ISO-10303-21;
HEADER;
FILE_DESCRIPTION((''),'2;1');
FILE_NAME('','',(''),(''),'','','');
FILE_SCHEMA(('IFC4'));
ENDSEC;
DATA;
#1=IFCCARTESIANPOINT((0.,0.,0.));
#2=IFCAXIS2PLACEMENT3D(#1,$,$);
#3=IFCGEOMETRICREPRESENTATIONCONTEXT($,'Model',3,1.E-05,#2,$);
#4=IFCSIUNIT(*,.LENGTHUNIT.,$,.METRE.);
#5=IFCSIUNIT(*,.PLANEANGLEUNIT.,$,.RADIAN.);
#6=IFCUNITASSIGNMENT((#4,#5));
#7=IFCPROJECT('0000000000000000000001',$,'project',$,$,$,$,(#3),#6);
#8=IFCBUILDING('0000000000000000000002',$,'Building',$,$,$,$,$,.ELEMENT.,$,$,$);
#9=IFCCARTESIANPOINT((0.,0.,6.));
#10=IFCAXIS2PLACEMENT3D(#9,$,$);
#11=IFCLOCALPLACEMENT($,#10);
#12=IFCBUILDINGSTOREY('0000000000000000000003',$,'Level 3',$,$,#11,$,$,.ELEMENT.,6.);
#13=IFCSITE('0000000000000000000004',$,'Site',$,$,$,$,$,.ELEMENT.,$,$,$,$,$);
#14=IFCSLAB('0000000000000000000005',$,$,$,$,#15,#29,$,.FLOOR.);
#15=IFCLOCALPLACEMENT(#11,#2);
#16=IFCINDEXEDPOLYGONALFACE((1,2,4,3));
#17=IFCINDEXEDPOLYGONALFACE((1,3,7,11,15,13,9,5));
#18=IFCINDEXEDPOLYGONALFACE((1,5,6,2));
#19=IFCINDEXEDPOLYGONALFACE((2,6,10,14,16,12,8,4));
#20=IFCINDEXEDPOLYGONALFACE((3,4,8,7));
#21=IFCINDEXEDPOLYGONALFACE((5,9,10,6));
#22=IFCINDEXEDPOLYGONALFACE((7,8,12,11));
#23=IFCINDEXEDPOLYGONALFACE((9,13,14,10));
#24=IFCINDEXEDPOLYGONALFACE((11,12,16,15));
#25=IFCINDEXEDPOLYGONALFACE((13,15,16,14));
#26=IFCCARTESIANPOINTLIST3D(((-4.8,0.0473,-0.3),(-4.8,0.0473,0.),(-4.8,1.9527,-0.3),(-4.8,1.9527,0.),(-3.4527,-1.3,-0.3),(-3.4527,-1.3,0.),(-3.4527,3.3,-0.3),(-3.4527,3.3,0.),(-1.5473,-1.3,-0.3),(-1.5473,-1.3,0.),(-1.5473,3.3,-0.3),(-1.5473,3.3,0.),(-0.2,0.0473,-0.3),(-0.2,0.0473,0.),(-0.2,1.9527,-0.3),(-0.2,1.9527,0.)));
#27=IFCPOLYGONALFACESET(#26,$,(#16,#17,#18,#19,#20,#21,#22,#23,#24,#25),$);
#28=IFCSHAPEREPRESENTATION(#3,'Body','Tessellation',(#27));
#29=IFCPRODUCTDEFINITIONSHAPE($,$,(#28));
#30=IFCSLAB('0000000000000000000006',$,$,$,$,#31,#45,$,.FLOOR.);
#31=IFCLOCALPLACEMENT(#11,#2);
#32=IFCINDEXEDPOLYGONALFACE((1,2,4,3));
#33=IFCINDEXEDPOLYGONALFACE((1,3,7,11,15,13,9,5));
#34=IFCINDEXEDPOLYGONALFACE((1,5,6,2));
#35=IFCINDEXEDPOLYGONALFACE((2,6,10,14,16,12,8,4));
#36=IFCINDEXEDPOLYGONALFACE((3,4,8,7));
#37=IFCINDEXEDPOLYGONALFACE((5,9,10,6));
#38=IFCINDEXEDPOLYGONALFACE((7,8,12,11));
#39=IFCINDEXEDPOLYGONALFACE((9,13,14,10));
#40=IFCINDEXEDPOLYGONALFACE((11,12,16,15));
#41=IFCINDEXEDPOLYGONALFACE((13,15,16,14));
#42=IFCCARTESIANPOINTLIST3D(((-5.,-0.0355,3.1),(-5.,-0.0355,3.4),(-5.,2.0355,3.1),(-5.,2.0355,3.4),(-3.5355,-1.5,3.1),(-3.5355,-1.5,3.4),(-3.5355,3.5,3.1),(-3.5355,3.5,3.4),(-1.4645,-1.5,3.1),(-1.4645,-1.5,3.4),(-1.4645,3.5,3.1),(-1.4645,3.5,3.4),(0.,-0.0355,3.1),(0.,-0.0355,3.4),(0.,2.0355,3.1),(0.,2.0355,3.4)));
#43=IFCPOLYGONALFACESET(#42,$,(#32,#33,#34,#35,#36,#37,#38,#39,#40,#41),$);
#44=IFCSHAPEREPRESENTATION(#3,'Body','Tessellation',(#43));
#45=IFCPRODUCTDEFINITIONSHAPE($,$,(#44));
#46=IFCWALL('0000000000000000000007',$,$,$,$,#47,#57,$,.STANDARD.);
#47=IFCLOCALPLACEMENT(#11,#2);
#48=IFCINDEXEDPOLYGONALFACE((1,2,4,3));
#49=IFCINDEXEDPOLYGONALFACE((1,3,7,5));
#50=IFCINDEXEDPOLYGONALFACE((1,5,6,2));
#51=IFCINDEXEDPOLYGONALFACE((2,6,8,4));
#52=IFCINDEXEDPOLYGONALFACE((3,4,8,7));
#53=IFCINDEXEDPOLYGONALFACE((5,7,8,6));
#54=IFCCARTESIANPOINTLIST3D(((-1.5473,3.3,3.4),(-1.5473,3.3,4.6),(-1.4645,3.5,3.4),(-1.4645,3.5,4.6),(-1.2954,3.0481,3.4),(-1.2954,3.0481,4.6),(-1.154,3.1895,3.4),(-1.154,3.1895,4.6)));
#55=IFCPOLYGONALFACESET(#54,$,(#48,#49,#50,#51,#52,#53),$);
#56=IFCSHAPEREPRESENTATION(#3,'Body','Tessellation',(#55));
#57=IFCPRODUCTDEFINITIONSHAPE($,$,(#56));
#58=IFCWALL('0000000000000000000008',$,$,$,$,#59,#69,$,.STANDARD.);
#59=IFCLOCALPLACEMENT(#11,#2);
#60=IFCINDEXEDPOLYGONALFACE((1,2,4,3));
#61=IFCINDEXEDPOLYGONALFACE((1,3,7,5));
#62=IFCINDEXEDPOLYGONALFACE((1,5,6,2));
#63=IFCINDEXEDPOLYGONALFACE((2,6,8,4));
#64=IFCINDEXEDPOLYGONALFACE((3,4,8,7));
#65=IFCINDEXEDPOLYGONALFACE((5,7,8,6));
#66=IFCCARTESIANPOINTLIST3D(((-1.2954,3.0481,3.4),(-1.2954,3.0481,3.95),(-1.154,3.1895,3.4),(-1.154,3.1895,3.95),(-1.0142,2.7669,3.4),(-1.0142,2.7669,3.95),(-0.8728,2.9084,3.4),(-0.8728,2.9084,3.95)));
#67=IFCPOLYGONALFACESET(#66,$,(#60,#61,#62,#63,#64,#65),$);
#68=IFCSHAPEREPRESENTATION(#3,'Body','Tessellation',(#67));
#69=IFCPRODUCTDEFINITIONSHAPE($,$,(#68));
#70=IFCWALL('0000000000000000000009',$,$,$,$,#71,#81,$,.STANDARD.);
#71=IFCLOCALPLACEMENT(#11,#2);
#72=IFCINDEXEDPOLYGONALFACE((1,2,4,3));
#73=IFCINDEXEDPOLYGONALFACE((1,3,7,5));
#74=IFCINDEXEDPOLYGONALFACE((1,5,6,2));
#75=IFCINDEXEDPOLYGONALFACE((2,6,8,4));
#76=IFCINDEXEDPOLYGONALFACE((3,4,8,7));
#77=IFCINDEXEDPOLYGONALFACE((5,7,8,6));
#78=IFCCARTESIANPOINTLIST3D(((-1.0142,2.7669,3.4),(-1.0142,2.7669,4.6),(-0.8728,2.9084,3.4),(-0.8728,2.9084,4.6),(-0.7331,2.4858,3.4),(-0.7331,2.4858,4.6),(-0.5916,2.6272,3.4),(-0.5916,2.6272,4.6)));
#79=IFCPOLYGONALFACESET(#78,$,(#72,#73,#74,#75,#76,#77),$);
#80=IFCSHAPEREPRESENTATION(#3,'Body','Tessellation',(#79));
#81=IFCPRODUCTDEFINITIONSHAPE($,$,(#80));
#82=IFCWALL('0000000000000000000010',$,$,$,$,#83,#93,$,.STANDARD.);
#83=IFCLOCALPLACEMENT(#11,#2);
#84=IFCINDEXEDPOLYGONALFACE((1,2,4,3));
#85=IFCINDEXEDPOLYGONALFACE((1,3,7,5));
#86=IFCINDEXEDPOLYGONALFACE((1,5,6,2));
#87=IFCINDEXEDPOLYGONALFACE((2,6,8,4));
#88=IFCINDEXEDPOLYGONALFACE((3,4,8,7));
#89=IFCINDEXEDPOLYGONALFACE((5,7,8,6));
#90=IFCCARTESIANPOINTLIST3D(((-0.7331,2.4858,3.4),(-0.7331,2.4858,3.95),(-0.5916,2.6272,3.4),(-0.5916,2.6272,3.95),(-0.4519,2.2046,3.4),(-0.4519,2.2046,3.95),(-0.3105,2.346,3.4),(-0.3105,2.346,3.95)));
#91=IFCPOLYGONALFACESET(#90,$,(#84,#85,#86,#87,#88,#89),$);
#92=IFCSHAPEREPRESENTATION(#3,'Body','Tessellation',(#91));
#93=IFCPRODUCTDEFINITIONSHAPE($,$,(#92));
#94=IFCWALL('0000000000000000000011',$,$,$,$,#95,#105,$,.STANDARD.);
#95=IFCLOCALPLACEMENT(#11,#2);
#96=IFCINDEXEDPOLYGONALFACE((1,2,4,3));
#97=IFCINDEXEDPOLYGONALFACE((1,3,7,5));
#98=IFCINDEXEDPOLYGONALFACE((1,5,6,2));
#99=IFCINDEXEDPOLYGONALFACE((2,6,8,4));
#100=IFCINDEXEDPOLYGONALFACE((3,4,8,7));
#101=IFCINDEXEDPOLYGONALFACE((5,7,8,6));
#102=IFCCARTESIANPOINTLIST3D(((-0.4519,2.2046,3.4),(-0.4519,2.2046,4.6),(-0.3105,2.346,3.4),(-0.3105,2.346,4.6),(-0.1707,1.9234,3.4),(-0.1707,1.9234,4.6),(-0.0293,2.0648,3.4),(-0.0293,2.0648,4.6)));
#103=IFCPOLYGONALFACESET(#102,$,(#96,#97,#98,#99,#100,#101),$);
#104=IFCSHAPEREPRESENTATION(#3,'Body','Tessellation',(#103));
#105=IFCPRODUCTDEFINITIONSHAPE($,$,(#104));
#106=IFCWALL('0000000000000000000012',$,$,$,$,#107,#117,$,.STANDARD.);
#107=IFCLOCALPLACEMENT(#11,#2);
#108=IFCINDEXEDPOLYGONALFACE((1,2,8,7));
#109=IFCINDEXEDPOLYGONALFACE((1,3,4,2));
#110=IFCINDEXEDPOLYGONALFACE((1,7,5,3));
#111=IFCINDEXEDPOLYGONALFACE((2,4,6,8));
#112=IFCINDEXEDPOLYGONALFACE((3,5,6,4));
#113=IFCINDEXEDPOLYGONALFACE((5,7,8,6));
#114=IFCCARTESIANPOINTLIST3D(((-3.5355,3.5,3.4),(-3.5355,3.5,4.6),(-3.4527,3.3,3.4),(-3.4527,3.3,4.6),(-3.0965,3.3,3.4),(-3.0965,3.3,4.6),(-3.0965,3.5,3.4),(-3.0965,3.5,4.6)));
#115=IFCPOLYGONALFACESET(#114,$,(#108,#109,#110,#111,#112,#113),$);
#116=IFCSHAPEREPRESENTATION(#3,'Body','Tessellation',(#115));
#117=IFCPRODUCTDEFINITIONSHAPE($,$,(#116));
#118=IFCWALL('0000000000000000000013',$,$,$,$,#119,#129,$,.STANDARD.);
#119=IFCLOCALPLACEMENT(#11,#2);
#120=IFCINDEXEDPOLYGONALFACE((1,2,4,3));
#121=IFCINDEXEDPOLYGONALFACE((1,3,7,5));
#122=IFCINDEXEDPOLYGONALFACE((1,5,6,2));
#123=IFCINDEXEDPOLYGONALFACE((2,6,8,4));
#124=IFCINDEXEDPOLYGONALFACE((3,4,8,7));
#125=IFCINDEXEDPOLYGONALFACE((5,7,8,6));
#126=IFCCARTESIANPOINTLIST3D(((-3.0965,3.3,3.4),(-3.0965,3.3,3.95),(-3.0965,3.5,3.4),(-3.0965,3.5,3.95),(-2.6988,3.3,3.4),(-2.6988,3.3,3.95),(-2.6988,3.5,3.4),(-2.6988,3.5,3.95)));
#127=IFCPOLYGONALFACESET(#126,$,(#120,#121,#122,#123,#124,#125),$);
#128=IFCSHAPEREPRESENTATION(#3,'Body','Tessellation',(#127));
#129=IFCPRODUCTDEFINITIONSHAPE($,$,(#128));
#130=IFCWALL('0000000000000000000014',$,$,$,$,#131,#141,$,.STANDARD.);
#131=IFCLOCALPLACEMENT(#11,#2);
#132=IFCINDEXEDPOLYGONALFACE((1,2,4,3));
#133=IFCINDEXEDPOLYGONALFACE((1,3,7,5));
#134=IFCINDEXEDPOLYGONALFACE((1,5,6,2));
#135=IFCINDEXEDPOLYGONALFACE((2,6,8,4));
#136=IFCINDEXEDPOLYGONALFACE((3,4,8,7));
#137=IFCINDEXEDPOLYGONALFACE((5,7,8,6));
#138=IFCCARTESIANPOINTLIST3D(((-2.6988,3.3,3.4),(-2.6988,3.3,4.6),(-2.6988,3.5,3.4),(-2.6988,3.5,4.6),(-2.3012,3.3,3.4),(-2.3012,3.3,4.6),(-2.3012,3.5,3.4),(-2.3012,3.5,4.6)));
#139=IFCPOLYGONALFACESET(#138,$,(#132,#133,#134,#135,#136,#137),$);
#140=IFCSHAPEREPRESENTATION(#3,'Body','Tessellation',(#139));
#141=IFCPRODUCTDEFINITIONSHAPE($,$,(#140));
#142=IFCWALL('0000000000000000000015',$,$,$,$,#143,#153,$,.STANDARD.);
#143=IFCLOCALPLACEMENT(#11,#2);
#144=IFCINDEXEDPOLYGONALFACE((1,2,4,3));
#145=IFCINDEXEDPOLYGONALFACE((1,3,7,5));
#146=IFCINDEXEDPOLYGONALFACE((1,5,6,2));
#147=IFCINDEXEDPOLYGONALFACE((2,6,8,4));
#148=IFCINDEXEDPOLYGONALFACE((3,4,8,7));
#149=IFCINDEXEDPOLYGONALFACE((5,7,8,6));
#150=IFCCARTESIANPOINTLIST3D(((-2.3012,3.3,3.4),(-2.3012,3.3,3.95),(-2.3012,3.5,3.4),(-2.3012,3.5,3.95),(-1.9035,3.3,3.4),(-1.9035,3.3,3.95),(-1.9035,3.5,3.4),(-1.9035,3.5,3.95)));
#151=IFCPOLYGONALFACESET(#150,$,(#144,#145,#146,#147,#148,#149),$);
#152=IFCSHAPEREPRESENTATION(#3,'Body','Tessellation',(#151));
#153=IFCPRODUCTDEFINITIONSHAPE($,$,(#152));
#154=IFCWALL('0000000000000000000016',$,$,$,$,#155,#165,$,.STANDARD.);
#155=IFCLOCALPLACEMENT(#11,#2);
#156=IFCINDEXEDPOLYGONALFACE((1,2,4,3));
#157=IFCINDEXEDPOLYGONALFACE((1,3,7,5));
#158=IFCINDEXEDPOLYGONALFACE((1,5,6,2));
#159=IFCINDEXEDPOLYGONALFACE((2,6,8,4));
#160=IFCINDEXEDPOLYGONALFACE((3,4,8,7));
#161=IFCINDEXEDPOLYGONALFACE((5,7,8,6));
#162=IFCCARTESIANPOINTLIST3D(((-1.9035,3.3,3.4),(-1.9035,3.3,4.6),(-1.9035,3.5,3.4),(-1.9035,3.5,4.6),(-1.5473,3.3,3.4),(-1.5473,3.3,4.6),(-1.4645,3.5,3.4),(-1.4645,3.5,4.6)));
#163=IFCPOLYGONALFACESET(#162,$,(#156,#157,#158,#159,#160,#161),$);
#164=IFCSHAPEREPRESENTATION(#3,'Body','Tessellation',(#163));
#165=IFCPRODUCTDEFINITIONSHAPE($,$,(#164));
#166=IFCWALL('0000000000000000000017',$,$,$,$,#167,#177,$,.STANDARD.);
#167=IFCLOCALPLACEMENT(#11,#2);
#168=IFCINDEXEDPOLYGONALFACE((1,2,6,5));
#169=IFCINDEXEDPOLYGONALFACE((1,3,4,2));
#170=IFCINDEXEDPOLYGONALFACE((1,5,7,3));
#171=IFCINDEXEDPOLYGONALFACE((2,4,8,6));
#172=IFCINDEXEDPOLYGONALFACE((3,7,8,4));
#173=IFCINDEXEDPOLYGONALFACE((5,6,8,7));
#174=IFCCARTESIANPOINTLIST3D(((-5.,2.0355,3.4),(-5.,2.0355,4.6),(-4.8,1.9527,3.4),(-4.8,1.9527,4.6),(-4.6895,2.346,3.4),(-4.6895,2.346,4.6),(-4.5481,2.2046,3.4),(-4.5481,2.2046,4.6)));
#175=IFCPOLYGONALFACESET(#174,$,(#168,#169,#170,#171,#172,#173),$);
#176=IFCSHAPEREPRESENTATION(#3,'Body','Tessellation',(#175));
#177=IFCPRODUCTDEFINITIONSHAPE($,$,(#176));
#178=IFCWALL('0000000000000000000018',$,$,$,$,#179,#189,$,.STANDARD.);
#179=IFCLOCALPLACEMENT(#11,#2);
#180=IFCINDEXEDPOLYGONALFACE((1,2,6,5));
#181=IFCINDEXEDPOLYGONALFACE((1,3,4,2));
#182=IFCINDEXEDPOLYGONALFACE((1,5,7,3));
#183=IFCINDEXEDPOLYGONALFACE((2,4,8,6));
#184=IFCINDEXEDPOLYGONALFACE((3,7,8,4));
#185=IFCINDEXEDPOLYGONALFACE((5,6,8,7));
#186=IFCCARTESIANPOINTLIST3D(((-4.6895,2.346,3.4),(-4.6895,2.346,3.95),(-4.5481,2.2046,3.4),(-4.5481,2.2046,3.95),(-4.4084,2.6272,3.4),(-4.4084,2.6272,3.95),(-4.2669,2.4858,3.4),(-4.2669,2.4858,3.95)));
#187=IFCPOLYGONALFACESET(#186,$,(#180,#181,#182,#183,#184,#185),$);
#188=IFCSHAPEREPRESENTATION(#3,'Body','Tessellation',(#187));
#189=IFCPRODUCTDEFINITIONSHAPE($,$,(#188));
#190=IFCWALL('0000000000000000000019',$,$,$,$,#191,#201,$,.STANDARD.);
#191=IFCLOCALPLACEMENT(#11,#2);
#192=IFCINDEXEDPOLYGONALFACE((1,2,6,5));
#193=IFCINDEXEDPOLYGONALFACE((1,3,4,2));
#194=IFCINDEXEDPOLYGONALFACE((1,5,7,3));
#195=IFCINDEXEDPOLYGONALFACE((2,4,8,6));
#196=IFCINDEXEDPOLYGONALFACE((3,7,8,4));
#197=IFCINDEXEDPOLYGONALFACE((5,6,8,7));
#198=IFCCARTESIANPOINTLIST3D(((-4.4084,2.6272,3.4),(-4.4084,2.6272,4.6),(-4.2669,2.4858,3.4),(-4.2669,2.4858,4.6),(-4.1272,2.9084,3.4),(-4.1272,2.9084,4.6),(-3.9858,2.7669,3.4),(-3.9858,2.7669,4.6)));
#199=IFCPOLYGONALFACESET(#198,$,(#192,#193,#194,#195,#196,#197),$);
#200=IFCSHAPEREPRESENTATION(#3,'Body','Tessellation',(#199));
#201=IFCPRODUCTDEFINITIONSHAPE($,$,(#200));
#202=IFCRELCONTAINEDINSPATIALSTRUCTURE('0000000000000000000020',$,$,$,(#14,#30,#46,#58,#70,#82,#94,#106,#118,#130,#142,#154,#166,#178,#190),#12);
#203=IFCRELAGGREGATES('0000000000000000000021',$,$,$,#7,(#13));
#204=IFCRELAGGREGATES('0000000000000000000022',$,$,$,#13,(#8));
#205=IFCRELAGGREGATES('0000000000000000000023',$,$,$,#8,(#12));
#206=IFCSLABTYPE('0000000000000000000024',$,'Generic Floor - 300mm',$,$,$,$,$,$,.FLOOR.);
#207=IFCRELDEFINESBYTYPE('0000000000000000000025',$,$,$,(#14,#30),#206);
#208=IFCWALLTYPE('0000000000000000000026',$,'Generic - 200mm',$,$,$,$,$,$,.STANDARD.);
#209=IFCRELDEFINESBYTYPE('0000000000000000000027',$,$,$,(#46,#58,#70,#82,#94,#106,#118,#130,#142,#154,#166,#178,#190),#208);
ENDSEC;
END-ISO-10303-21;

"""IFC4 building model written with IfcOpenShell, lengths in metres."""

from ifc_helpers import new_model, si_unit, frame, frame_2d, origin, place, context, project, spatial, polyline, rectangle, outline, extrude, type_object, element, save


model = new_model("IFC4")

# Units and contexts
model_context = context("Model", 3, precision=1e-05, world=origin())
ifc_project = project(units=[si_unit("LENGTHUNIT", "METRE"), si_unit("PLANEANGLEUNIT", "RADIAN")], contexts=[model_context])

# Site, building, storey
site = spatial("IfcSite", under=ifc_project, Name="Site", CompositionType="ELEMENT")
building = spatial("IfcBuilding", under=site, Name="Building", CompositionType="ELEMENT")
storey_placement = place(None, frame((0.0, 0.0, 6.0)))
storey = spatial("IfcBuildingStorey", under=building, at=storey_placement, Name="Level 3", CompositionType="ELEMENT", Elevation=6.0)

# Slabs
slab_type = type_object("IfcSlabType", Name="Generic Floor - 300mm", PredefinedType="FLOOR")
slab_1_placement = place(None, frame((0.0, 0.0, 6.0)))
element("IfcSlab", 1, at=slab_1_placement, inside=storey, type_object=slab_type, PredefinedType="FLOOR", context=model_context, shape_type="SweptSolid", body=[
    extrude(outline(polyline([(-0.2, 1.9527), (-1.5473, 3.3), (-3.4527, 3.3), (-4.8, 1.9527), (-4.8, 0.0473), (-3.4527, -1.3), (-1.5473, -1.3), (-0.2, 0.0473), (-0.2, 1.9527)])), origin(), (0.0, 0.0, -1.0), 0.3),
])
slab_2_placement = place(None, frame((0.0, 0.0, 9.4)))
element("IfcSlab", 2, at=slab_2_placement, inside=storey, type_object=slab_type, PredefinedType="FLOOR", context=model_context, shape_type="SweptSolid", body=[
    extrude(outline(polyline([(0.0, 2.0355), (-1.4645, 3.5), (-3.5355, 3.5), (-5.0, 2.0355), (-5.0, -0.0355), (-3.5355, -1.5), (-1.4645, -1.5), (0.0, -0.0355), (0.0, 2.0355)])), origin(), (0.0, 0.0, -1.0), 0.3),
])

# Walls
wall_type = type_object("IfcWallType", Name="Generic - 200mm", PredefinedType="STANDARD")
wall_1_placement = place(None, frame((-1.5059, 3.4, 9.4), z_axis=(0.0, 0.0, 1.0), x_axis=(0.707107, -0.707107, 0.0)))
element("IfcWall", 3, at=wall_1_placement, inside=storey, type_object=wall_type, PredefinedType="STANDARD", context=model_context, shape_type="SweptSolid", body=[
    extrude(outline(polyline([(0.0414, -0.1), (0.3976, -0.1), (0.3976, 0.1), (-0.0414, 0.1), (0.0414, -0.1)])), origin(), (0.0, 0.0, 1.0), 1.2),
])
wall_2_placement = place(None, frame((-1.2247, 3.1188, 9.4), z_axis=(0.0, 0.0, 1.0), x_axis=(0.707107, -0.707107, 0.0)))
element("IfcWall", 4, at=wall_2_placement, inside=storey, type_object=wall_type, PredefinedType="STANDARD", context=model_context, shape_type="SweptSolid", body=[
    extrude(rectangle(XDim=0.3976, YDim=0.2, at=frame_2d((0.1988, 0.0))), origin(), (0.0, 0.0, 1.0), 0.55),
])
wall_3_placement = place(None, frame((-0.9435, 2.8376, 9.4), z_axis=(0.0, 0.0, 1.0), x_axis=(0.707107, -0.707107, 0.0)))
element("IfcWall", 5, at=wall_3_placement, inside=storey, type_object=wall_type, PredefinedType="STANDARD", context=model_context, shape_type="SweptSolid", body=[
    extrude(rectangle(XDim=0.3976, YDim=0.2, at=frame_2d((0.1988, 0.0))), origin(), (0.0, 0.0, 1.0), 1.2),
])
wall_4_placement = place(None, frame((-0.6624, 2.5565, 9.4), z_axis=(0.0, 0.0, 1.0), x_axis=(0.707107, -0.707107, 0.0)))
element("IfcWall", 6, at=wall_4_placement, inside=storey, type_object=wall_type, PredefinedType="STANDARD", context=model_context, shape_type="SweptSolid", body=[
    extrude(rectangle(XDim=0.3976, YDim=0.2, at=frame_2d((0.1988, 0.0))), origin(), (0.0, 0.0, 1.0), 0.55),
])
wall_5_placement = place(None, frame((-0.3812, 2.2753, 9.4), z_axis=(0.0, 0.0, 1.0), x_axis=(0.707107, -0.707107, 0.0)))
element("IfcWall", 7, at=wall_5_placement, inside=storey, type_object=wall_type, PredefinedType="STANDARD", context=model_context, shape_type="SweptSolid", body=[
    extrude(rectangle(XDim=0.3976, YDim=0.2, at=frame_2d((0.1988, 0.0))), origin(), (0.0, 0.0, 1.0), 1.2),
])
wall_6_placement = place(None, frame((-3.4941, 3.4, 9.4), z_axis=(0.0, 0.0, 1.0), x_axis=(1.0, 0.0, 0.0)))
element("IfcWall", 8, at=wall_6_placement, inside=storey, type_object=wall_type, PredefinedType="STANDARD", context=model_context, shape_type="SweptSolid", body=[
    extrude(outline(polyline([(0.0414, -0.1), (0.3976, -0.1), (0.3976, 0.1), (-0.0414, 0.1), (0.0414, -0.1)])), origin(), (0.0, 0.0, 1.0), 1.2),
])
wall_7_placement = place(None, frame((-3.0965, 3.4, 9.4), z_axis=(0.0, 0.0, 1.0), x_axis=(1.0, 0.0, 0.0)))
element("IfcWall", 9, at=wall_7_placement, inside=storey, type_object=wall_type, PredefinedType="STANDARD", context=model_context, shape_type="SweptSolid", body=[
    extrude(rectangle(XDim=0.3976, YDim=0.2, at=frame_2d((0.1988, 0.0))), origin(), (0.0, 0.0, 1.0), 0.55),
])
wall_8_placement = place(None, frame((-2.6988, 3.4, 9.4), z_axis=(0.0, 0.0, 1.0), x_axis=(1.0, 0.0, 0.0)))
element("IfcWall", 10, at=wall_8_placement, inside=storey, type_object=wall_type, PredefinedType="STANDARD", context=model_context, shape_type="SweptSolid", body=[
    extrude(rectangle(XDim=0.3976, YDim=0.2, at=frame_2d((0.1988, 0.0))), origin(), (0.0, 0.0, 1.0), 1.2),
])
wall_9_placement = place(None, frame((-2.3012, 3.4, 9.4), z_axis=(0.0, 0.0, 1.0), x_axis=(1.0, 0.0, 0.0)))
element("IfcWall", 11, at=wall_9_placement, inside=storey, type_object=wall_type, PredefinedType="STANDARD", context=model_context, shape_type="SweptSolid", body=[
    extrude(rectangle(XDim=0.3976, YDim=0.2, at=frame_2d((0.1988, 0.0))), origin(), (0.0, 0.0, 1.0), 0.55),
])
wall_10_placement = place(None, frame((-1.9035, 3.4, 9.4), z_axis=(0.0, 0.0, 1.0), x_axis=(1.0, 0.0, 0.0)))
element("IfcWall", 12, at=wall_10_placement, inside=storey, type_object=wall_type, PredefinedType="STANDARD", context=model_context, shape_type="SweptSolid", body=[
    extrude(outline(polyline([(0.0, -0.1), (0.3562, -0.1), (0.4391, 0.1), (0.0, 0.1), (0.0, -0.1)])), origin(), (0.0, 0.0, 1.0), 1.2),
])
wall_11_placement = place(None, frame((-4.9, 1.9941, 9.4), z_axis=(0.0, 0.0, 1.0), x_axis=(0.707107, 0.707107, 0.0)))
element("IfcWall", 13, at=wall_11_placement, inside=storey, type_object=wall_type, PredefinedType="STANDARD", context=model_context, shape_type="SweptSolid", body=[
    extrude(outline(polyline([(0.0414, -0.1), (0.3976, -0.1), (0.3976, 0.1), (-0.0414, 0.1), (0.0414, -0.1)])), origin(), (0.0, 0.0, 1.0), 1.2),
])
wall_12_placement = place(None, frame((-4.6188, 2.2753, 9.4), z_axis=(0.0, 0.0, 1.0), x_axis=(0.707107, 0.707107, 0.0)))
element("IfcWall", 14, at=wall_12_placement, inside=storey, type_object=wall_type, PredefinedType="STANDARD", context=model_context, shape_type="SweptSolid", body=[
    extrude(rectangle(XDim=0.3976, YDim=0.2, at=frame_2d((0.1988, 0.0))), origin(), (0.0, 0.0, 1.0), 0.55),
])
wall_13_placement = place(None, frame((-4.3376, 2.5565, 9.4), z_axis=(0.0, 0.0, 1.0), x_axis=(0.707107, 0.707107, 0.0)))
element("IfcWall", 15, at=wall_13_placement, inside=storey, type_object=wall_type, PredefinedType="STANDARD", context=model_context, shape_type="SweptSolid", body=[
    extrude(rectangle(XDim=0.3976, YDim=0.2, at=frame_2d((0.1988, 0.0))), origin(), (0.0, 0.0, 1.0), 1.2),
])

save(model, "model.ifc")
